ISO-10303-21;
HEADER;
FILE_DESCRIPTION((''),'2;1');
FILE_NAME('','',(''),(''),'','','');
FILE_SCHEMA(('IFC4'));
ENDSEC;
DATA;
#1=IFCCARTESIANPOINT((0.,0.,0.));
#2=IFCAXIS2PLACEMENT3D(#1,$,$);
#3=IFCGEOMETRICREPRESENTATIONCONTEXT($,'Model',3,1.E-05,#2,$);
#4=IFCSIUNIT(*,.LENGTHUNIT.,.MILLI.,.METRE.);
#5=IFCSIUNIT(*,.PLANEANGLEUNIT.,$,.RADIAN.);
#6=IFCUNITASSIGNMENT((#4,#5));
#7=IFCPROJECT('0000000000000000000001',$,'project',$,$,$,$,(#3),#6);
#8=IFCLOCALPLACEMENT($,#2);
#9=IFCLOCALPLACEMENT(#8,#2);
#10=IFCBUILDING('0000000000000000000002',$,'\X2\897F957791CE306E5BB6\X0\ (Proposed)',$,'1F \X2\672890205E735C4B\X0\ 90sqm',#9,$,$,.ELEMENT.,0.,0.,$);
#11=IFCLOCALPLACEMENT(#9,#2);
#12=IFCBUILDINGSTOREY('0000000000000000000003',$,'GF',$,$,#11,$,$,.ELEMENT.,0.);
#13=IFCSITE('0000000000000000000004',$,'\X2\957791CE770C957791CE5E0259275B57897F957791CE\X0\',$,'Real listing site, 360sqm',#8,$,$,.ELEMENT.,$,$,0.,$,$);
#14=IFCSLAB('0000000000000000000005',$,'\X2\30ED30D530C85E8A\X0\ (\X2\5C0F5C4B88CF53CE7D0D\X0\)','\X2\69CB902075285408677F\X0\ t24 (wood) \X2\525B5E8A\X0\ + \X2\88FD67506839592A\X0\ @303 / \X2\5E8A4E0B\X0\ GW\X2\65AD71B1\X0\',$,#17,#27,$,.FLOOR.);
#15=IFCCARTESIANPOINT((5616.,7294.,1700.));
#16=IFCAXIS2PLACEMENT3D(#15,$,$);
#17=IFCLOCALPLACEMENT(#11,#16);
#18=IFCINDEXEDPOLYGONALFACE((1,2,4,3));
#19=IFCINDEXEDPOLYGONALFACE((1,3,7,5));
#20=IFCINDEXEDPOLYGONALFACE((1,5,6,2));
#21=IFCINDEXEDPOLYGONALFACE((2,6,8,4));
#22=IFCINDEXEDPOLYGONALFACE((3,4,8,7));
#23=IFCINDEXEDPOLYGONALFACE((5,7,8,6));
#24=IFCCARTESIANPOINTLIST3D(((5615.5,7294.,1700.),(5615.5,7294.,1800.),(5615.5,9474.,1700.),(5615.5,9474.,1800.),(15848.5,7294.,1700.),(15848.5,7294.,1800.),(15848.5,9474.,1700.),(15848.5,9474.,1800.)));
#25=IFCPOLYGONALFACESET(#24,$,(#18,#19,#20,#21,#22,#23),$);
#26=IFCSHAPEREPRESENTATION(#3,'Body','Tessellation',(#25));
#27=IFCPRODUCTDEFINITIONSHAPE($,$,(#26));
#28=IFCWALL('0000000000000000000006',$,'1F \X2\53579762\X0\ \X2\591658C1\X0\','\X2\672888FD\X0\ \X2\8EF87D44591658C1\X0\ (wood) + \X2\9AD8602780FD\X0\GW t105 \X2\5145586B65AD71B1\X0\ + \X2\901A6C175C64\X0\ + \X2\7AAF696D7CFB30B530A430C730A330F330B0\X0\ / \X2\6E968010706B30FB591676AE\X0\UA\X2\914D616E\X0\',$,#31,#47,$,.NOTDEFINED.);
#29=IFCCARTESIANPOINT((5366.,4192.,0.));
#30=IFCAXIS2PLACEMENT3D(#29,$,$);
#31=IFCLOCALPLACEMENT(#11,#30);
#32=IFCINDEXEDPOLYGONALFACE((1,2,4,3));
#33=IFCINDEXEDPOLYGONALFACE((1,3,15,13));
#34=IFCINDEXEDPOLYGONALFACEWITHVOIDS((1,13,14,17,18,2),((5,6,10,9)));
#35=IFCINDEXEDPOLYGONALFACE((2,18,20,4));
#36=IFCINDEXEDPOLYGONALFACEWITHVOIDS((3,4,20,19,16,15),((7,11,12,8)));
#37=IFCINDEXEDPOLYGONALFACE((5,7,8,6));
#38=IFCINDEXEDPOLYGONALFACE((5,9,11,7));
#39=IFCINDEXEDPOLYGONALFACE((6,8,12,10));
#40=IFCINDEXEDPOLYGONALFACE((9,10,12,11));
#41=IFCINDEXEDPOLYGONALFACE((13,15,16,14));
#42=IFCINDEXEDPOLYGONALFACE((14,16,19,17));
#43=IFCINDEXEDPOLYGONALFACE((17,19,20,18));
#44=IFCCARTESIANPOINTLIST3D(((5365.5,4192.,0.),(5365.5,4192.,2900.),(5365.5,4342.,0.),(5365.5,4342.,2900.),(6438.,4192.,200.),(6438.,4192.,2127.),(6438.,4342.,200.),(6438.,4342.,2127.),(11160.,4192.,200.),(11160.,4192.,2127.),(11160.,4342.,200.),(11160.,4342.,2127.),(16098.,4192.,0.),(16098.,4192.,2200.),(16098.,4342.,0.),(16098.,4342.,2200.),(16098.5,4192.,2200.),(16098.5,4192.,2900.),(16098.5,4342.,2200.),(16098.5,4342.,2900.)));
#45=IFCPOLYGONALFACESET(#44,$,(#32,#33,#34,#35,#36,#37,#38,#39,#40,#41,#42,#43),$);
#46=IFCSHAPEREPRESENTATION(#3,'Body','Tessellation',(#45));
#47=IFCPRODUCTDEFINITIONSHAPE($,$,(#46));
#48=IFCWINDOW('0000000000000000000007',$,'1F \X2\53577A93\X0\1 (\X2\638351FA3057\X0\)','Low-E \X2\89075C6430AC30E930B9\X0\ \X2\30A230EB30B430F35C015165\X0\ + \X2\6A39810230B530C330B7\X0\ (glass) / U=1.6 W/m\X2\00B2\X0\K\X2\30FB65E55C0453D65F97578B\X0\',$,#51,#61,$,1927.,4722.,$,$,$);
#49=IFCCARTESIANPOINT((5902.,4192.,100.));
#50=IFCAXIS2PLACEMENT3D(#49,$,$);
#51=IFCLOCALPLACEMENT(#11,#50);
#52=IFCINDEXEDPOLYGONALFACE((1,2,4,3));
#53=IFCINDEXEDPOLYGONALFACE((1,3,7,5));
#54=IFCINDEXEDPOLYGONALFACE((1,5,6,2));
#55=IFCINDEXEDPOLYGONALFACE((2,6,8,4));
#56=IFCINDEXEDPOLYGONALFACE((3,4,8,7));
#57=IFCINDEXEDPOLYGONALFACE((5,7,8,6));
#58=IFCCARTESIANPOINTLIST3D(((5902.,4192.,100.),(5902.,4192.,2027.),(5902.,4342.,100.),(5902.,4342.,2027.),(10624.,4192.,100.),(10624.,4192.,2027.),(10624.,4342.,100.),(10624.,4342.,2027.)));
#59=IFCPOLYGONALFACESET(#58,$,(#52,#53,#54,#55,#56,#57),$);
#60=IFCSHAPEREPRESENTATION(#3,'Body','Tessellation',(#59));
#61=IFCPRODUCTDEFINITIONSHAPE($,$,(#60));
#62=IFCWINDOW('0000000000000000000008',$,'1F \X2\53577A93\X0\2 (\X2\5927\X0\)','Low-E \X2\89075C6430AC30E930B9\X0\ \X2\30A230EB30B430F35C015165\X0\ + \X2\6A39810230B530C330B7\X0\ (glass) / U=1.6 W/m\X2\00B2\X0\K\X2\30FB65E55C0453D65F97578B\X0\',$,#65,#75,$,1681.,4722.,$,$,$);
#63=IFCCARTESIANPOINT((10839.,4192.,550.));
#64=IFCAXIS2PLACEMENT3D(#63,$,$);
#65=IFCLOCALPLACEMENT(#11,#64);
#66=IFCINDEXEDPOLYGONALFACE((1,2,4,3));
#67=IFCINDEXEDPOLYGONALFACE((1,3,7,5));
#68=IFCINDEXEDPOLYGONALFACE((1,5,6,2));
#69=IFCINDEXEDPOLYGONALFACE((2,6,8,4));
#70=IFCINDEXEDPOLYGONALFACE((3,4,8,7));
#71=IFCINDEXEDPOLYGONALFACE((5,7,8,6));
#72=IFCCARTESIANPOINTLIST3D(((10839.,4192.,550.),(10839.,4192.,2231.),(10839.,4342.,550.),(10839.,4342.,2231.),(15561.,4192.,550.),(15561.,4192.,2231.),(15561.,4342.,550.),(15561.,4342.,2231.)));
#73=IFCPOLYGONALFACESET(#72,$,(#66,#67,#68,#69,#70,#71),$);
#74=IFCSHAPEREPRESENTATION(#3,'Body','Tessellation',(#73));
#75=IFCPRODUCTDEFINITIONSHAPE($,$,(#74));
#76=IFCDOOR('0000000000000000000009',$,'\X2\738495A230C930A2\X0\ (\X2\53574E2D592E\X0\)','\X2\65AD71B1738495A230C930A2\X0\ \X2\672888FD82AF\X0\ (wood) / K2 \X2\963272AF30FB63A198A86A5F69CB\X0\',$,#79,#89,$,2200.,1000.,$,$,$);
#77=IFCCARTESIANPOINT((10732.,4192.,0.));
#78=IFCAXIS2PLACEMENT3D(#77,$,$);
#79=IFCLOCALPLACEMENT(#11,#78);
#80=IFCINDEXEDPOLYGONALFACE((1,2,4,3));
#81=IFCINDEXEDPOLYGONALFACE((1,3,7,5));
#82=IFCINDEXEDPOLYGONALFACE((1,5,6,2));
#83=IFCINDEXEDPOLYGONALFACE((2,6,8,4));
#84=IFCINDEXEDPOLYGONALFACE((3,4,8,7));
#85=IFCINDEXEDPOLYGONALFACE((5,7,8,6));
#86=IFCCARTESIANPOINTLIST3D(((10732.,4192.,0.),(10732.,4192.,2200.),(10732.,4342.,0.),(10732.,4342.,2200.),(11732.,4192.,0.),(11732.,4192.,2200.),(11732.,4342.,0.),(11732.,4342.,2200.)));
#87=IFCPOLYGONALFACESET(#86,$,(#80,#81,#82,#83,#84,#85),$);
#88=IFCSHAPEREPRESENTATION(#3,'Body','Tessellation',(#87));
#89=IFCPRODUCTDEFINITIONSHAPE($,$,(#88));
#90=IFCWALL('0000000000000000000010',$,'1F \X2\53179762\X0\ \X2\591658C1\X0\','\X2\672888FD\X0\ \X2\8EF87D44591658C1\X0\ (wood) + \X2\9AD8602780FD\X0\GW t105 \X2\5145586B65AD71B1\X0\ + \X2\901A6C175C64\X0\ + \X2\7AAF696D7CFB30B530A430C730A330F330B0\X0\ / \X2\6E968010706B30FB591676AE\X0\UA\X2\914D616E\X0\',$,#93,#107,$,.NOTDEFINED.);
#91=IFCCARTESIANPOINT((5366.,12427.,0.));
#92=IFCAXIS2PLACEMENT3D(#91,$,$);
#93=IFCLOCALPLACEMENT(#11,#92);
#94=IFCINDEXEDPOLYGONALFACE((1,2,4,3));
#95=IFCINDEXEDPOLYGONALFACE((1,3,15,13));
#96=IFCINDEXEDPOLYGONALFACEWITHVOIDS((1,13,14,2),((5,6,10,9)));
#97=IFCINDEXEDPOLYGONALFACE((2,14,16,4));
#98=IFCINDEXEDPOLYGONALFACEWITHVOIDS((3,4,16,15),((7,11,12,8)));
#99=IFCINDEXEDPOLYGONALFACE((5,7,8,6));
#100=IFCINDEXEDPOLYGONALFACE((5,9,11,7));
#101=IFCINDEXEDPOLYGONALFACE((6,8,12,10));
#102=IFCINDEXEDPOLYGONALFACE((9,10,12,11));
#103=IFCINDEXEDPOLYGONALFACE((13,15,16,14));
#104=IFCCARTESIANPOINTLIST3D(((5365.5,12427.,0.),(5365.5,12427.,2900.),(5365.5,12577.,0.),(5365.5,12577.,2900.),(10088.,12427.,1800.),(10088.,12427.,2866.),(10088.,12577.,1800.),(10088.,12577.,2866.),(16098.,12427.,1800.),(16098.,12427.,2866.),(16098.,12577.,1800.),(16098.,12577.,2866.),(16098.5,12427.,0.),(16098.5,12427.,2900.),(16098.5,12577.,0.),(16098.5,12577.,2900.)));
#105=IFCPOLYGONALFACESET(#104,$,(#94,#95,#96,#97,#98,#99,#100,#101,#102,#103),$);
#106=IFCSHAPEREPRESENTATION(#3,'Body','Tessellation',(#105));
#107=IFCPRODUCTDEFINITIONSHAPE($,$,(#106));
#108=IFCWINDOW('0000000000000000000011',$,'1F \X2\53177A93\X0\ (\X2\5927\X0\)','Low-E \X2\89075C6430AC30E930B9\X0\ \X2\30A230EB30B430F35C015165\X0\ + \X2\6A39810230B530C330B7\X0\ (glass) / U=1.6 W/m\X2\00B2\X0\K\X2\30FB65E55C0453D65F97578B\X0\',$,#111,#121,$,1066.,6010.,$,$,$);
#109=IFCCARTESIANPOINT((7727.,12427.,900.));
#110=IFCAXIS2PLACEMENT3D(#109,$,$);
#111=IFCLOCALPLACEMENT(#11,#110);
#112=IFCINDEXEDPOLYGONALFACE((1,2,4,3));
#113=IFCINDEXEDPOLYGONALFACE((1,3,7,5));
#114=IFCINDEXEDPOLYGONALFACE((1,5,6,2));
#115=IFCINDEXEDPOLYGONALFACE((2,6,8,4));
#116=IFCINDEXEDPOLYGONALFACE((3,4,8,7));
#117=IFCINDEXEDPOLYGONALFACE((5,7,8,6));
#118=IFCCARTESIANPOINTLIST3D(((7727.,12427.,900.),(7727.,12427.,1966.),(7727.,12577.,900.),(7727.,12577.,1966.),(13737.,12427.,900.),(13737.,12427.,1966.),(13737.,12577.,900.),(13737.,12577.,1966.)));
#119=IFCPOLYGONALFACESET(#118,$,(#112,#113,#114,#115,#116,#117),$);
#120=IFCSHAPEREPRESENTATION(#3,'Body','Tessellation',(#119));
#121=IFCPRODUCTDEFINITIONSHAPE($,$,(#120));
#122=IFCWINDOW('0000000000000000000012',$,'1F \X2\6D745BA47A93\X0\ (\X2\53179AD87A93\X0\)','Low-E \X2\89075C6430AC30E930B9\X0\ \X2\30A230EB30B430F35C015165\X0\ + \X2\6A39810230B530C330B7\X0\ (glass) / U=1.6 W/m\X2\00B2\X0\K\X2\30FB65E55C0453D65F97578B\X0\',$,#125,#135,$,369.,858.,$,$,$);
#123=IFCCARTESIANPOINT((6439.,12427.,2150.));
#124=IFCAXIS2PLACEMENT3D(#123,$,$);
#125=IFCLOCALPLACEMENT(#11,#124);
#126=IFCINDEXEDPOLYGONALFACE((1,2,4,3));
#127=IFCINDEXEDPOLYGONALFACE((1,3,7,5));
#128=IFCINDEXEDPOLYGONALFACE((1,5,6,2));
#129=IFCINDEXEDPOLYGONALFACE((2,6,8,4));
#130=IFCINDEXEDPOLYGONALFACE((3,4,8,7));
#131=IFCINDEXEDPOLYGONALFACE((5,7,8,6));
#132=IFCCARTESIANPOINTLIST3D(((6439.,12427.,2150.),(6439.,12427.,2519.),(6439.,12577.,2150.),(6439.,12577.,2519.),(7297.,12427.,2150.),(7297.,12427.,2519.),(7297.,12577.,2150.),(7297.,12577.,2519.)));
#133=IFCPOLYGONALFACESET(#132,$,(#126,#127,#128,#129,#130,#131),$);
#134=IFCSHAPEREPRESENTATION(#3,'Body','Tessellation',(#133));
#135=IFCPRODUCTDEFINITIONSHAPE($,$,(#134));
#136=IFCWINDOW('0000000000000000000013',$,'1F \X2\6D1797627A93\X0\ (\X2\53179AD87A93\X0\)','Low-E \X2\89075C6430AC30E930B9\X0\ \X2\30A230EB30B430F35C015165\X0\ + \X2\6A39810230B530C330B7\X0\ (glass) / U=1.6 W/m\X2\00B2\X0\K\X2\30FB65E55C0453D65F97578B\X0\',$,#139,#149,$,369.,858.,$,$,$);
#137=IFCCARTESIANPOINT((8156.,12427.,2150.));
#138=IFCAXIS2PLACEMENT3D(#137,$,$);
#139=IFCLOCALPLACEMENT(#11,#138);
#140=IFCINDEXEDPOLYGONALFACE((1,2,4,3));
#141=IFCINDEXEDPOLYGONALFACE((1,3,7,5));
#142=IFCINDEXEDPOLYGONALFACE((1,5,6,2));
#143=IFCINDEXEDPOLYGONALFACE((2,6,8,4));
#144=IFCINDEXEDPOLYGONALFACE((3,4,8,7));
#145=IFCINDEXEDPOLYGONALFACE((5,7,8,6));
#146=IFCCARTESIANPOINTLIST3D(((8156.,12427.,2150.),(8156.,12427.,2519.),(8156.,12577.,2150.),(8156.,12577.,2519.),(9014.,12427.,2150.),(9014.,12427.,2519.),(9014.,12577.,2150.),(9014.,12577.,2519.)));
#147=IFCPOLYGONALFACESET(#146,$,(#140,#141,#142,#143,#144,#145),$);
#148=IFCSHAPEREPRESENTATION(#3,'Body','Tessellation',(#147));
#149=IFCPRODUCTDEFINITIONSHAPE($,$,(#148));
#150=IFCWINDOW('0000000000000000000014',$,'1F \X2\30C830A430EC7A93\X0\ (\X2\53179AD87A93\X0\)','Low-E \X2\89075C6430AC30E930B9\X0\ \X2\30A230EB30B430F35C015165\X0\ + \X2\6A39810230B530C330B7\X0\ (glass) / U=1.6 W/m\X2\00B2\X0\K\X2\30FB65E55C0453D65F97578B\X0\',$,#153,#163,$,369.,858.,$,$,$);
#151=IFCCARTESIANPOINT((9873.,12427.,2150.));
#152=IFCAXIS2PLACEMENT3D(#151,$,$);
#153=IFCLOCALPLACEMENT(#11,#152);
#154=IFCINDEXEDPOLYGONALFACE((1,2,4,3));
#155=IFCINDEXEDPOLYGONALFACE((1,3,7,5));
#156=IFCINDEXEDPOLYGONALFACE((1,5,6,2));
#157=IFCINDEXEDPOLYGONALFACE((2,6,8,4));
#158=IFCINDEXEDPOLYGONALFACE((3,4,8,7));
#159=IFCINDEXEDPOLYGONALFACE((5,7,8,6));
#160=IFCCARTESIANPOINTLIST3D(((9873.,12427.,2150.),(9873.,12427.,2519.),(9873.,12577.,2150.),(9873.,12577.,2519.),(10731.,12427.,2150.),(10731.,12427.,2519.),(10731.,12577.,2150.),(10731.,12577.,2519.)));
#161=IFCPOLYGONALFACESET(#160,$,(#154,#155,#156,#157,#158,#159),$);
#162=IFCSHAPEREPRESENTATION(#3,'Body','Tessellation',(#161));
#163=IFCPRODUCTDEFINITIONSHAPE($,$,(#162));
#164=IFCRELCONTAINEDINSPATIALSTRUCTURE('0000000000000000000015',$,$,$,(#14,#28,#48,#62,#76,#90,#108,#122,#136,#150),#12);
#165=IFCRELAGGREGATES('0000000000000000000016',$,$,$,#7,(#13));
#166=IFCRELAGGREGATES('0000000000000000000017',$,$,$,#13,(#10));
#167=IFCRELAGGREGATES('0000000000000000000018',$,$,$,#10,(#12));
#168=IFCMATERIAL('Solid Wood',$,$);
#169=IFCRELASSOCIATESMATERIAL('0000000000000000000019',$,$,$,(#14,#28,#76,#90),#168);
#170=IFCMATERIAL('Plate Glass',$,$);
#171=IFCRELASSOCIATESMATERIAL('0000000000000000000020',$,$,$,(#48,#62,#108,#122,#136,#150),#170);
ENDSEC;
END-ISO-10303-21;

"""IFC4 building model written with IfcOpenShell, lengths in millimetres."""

from ifc_helpers import new_model, si_unit, frame, frame_2d, origin, place, context, project, spatial, rectangle, extrude, material, element, fill, save


model = new_model("IFC4")

# Units and contexts
model_context = context("Model", 3, precision=1e-05, world=origin())
ifc_project = project(units=[si_unit("LENGTHUNIT", "METRE", prefix="MILLI"), si_unit("PLANEANGLEUNIT", "RADIAN")], contexts=[model_context])

# Site, building, storey
site_placement = place(None, origin())
site = spatial("IfcSite", under=ifc_project, at=site_placement, Name="長野県長野市大字西長野", ObjectType="Real listing site, 360sqm", CompositionType="ELEMENT", RefElevation=0.0)
building_placement = place(site_placement, origin())
building = spatial("IfcBuilding", under=site, at=building_placement, Name="西長野の家 (Proposed)", ObjectType="1F 木造平屋 90sqm", CompositionType="ELEMENT", ElevationOfRefHeight=0.0, ElevationOfTerrain=0.0)
storey_placement = place(building_placement, origin())
storey = spatial("IfcBuildingStorey", under=building, at=storey_placement, Name="GF", CompositionType="ELEMENT", Elevation=0.0)

# Slab
ifc_material_1 = material(Name="Solid Wood")
slab_1_placement = place(storey_placement, frame((5616.0, 7294.0, 1700.0)))
element("IfcSlab", 1, at=slab_1_placement, inside=storey, material=ifc_material_1, Name="ロフト床 (小屋裏収納)", Description="構造用合板 t24 (wood) 剛床 + 製材根太 @303 / 床下 GW断熱", PredefinedType="FLOOR", context=model_context, shape_type="SweptSolid", body=[
    extrude(rectangle(XDim=10233.0, YDim=2180.0, at=frame_2d((5116.0, 1090.0))), frame((5616.0, 7294.0, 1700.0)), (0.0, 0.0, 1.0), 100.0),
])

# Wall, openings, windows, door
wall_1_placement = place(storey_placement, frame((5366.0, 4192.0, 0.0)))
wall_1 = element("IfcWall", 2, at=wall_1_placement, inside=storey, material=ifc_material_1, Name="1F 南面 外壁", Description="木製 軸組外壁 (wood) + 高性能GW t105 充填断熱 + 通気層 + 窯業系サイディング / 準耐火・外皮UA配慮", PredefinedType="NOTDEFINED", context=model_context, shape_type="SweptSolid", body=[
    extrude(rectangle(XDim=10733.0, YDim=150.0, at=frame_2d((5366.0, 75.0))), frame((5366.0, 4192.0, 0.0)), (0.0, 0.0, 1.0), 2900.0),
])
opening_1_placement = place(storey_placement, frame((5902.0, 4192.0, 100.0)))
opening_1 = element("IfcOpeningElement", 3, at=opening_1_placement, cuts=wall_1, PredefinedType="NOTDEFINED", context=model_context, shape_type="SweptSolid", body=[
    extrude(rectangle(XDim=4722.0, YDim=150.0, at=frame_2d((2361.0, 75.0))), frame((5902.0, 4192.0, 100.0)), (0.0, 0.0, 1.0), 1927.0),
])
opening_2_placement = place(storey_placement, frame((10839.0, 4192.0, 550.0)))
opening_2 = element("IfcOpeningElement", 4, at=opening_2_placement, cuts=wall_1, PredefinedType="NOTDEFINED", context=model_context, shape_type="SweptSolid", body=[
    extrude(rectangle(XDim=4722.0, YDim=150.0, at=frame_2d((2361.0, 75.0))), frame((10839.0, 4192.0, 550.0)), (0.0, 0.0, 1.0), 1681.0),
])
opening_3_placement = place(storey_placement, frame((10732.0, 4192.0, 0.0)))
opening_3 = element("IfcOpeningElement", 5, at=opening_3_placement, cuts=wall_1, PredefinedType="NOTDEFINED", context=model_context, shape_type="SweptSolid", body=[
    extrude(rectangle(XDim=1000.0, YDim=150.0, at=frame_2d((500.0, 75.0))), frame((10732.0, 4192.0, 0.0)), (0.0, 0.0, 1.0), 2200.0),
])
ifc_material_2 = material(Name="Plate Glass")
window_1_placement = place(storey_placement, frame((5902.0, 4192.0, 100.0)))
window_1 = element("IfcWindow", 6, at=window_1_placement, inside=storey, material=ifc_material_2, Name="1F 南窓1 (掃出し)", Description="Low-E 複層ガラス アルゴン封入 + 樹脂サッシ (glass) / U=1.6 W/m²K・日射取得型", OverallHeight=1927.0, OverallWidth=4722.0, context=model_context, shape_type="SweptSolid", body=[
    extrude(rectangle(XDim=4722.0, YDim=150.0, at=frame_2d((2361.0, 75.0))), frame((5902.0, 4192.0, 100.0)), (0.0, 0.0, 1.0), 1927.0),
])
fill(opening_1, window_1)
window_2_placement = place(storey_placement, frame((10839.0, 4192.0, 550.0)))
window_2 = element("IfcWindow", 7, at=window_2_placement, inside=storey, material=ifc_material_2, Name="1F 南窓2 (大)", Description="Low-E 複層ガラス アルゴン封入 + 樹脂サッシ (glass) / U=1.6 W/m²K・日射取得型", OverallHeight=1681.0, OverallWidth=4722.0, context=model_context, shape_type="SweptSolid", body=[
    extrude(rectangle(XDim=4722.0, YDim=150.0, at=frame_2d((2361.0, 75.0))), frame((10839.0, 4192.0, 550.0)), (0.0, 0.0, 1.0), 1681.0),
])
fill(opening_2, window_2)
door_1_placement = place(storey_placement, frame((10732.0, 4192.0, 0.0)))
door_1 = element("IfcDoor", 8, at=door_1_placement, inside=storey, material=ifc_material_1, Name="玄関ドア (南中央)", Description="断熱玄関ドア 木製芯 (wood) / K2 防犯・採風機構", OverallHeight=2200.0, OverallWidth=1000.0, context=model_context, shape_type="SweptSolid", body=[
    extrude(rectangle(XDim=1000.0, YDim=150.0, at=frame_2d((500.0, 75.0))), frame((10732.0, 4192.0, 0.0)), (0.0, 0.0, 1.0), 2200.0),
])
fill(opening_3, door_1)

# Wall, openings, windows
wall_2_placement = place(storey_placement, frame((5366.0, 12427.0, 0.0)))
wall_2 = element("IfcWall", 9, at=wall_2_placement, inside=storey, material=ifc_material_1, Name="1F 北面 外壁", Description="木製 軸組外壁 (wood) + 高性能GW t105 充填断熱 + 通気層 + 窯業系サイディング / 準耐火・外皮UA配慮", PredefinedType="NOTDEFINED", context=model_context, shape_type="SweptSolid", body=[
    extrude(rectangle(XDim=10733.0, YDim=150.0, at=frame_2d((5366.0, 75.0))), frame((5366.0, 12427.0, 0.0)), (0.0, 0.0, 1.0), 2900.0),
])
opening_4_placement = place(storey_placement, frame((7727.0, 12427.0, 900.0)))
opening_4 = element("IfcOpeningElement", 10, at=opening_4_placement, cuts=wall_2, PredefinedType="NOTDEFINED", context=model_context, shape_type="SweptSolid", body=[
    extrude(rectangle(XDim=6010.0, YDim=150.0, at=frame_2d((3005.0, 75.0))), frame((7727.0, 12427.0, 900.0)), (0.0, 0.0, 1.0), 1066.0),
])
opening_5_placement = place(storey_placement, frame((6439.0, 12427.0, 2150.0)))
opening_5 = element("IfcOpeningElement", 11, at=opening_5_placement, cuts=wall_2, PredefinedType="NOTDEFINED", context=model_context, shape_type="SweptSolid", body=[
    extrude(rectangle(XDim=858.0, YDim=150.0, at=frame_2d((429.0, 75.0))), frame((6439.0, 12427.0, 2150.0)), (0.0, 0.0, 1.0), 369.0),
])
opening_6_placement = place(storey_placement, frame((8156.0, 12427.0, 2150.0)))
opening_6 = element("IfcOpeningElement", 12, at=opening_6_placement, cuts=wall_2, PredefinedType="NOTDEFINED", context=model_context, shape_type="SweptSolid", body=[
    extrude(rectangle(XDim=858.0, YDim=150.0, at=frame_2d((429.0, 75.0))), frame((8156.0, 12427.0, 2150.0)), (0.0, 0.0, 1.0), 369.0),
])
opening_7_placement = place(storey_placement, frame((9873.0, 12427.0, 2150.0)))
opening_7 = element("IfcOpeningElement", 13, at=opening_7_placement, cuts=wall_2, PredefinedType="NOTDEFINED", context=model_context, shape_type="SweptSolid", body=[
    extrude(rectangle(XDim=858.0, YDim=150.0, at=frame_2d((429.0, 75.0))), frame((9873.0, 12427.0, 2150.0)), (0.0, 0.0, 1.0), 369.0),
])
window_3_placement = place(storey_placement, frame((7727.0, 12427.0, 900.0)))
window_3 = element("IfcWindow", 14, at=window_3_placement, inside=storey, material=ifc_material_2, Name="1F 北窓 (大)", Description="Low-E 複層ガラス アルゴン封入 + 樹脂サッシ (glass) / U=1.6 W/m²K・日射取得型", OverallHeight=1066.0, OverallWidth=6010.0, context=model_context, shape_type="SweptSolid", body=[
    extrude(rectangle(XDim=6010.0, YDim=150.0, at=frame_2d((3005.0, 75.0))), frame((7727.0, 12427.0, 900.0)), (0.0, 0.0, 1.0), 1066.0),
])
fill(opening_4, window_3)
window_4_placement = place(storey_placement, frame((6439.0, 12427.0, 2150.0)))
window_4 = element("IfcWindow", 15, at=window_4_placement, inside=storey, material=ifc_material_2, Name="1F 浴室窓 (北高窓)", Description="Low-E 複層ガラス アルゴン封入 + 樹脂サッシ (glass) / U=1.6 W/m²K・日射取得型", OverallHeight=369.0, OverallWidth=858.0, context=model_context, shape_type="SweptSolid", body=[
    extrude(rectangle(XDim=858.0, YDim=150.0, at=frame_2d((429.0, 75.0))), frame((6439.0, 12427.0, 2150.0)), (0.0, 0.0, 1.0), 369.0),
])
fill(opening_5, window_4)
window_5_placement = place(storey_placement, frame((8156.0, 12427.0, 2150.0)))
window_5 = element("IfcWindow", 16, at=window_5_placement, inside=storey, material=ifc_material_2, Name="1F 洗面窓 (北高窓)", Description="Low-E 複層ガラス アルゴン封入 + 樹脂サッシ (glass) / U=1.6 W/m²K・日射取得型", OverallHeight=369.0, OverallWidth=858.0, context=model_context, shape_type="SweptSolid", body=[
    extrude(rectangle(XDim=858.0, YDim=150.0, at=frame_2d((429.0, 75.0))), frame((8156.0, 12427.0, 2150.0)), (0.0, 0.0, 1.0), 369.0),
])
fill(opening_6, window_5)
window_6_placement = place(storey_placement, frame((9873.0, 12427.0, 2150.0)))
window_6 = element("IfcWindow", 17, at=window_6_placement, inside=storey, material=ifc_material_2, Name="1F トイレ窓 (北高窓)", Description="Low-E 複層ガラス アルゴン封入 + 樹脂サッシ (glass) / U=1.6 W/m²K・日射取得型", OverallHeight=369.0, OverallWidth=858.0, context=model_context, shape_type="SweptSolid", body=[
    extrude(rectangle(XDim=858.0, YDim=150.0, at=frame_2d((429.0, 75.0))), frame((9873.0, 12427.0, 2150.0)), (0.0, 0.0, 1.0), 369.0),
])
fill(opening_7, window_6)

save(model, "model.ifc")
